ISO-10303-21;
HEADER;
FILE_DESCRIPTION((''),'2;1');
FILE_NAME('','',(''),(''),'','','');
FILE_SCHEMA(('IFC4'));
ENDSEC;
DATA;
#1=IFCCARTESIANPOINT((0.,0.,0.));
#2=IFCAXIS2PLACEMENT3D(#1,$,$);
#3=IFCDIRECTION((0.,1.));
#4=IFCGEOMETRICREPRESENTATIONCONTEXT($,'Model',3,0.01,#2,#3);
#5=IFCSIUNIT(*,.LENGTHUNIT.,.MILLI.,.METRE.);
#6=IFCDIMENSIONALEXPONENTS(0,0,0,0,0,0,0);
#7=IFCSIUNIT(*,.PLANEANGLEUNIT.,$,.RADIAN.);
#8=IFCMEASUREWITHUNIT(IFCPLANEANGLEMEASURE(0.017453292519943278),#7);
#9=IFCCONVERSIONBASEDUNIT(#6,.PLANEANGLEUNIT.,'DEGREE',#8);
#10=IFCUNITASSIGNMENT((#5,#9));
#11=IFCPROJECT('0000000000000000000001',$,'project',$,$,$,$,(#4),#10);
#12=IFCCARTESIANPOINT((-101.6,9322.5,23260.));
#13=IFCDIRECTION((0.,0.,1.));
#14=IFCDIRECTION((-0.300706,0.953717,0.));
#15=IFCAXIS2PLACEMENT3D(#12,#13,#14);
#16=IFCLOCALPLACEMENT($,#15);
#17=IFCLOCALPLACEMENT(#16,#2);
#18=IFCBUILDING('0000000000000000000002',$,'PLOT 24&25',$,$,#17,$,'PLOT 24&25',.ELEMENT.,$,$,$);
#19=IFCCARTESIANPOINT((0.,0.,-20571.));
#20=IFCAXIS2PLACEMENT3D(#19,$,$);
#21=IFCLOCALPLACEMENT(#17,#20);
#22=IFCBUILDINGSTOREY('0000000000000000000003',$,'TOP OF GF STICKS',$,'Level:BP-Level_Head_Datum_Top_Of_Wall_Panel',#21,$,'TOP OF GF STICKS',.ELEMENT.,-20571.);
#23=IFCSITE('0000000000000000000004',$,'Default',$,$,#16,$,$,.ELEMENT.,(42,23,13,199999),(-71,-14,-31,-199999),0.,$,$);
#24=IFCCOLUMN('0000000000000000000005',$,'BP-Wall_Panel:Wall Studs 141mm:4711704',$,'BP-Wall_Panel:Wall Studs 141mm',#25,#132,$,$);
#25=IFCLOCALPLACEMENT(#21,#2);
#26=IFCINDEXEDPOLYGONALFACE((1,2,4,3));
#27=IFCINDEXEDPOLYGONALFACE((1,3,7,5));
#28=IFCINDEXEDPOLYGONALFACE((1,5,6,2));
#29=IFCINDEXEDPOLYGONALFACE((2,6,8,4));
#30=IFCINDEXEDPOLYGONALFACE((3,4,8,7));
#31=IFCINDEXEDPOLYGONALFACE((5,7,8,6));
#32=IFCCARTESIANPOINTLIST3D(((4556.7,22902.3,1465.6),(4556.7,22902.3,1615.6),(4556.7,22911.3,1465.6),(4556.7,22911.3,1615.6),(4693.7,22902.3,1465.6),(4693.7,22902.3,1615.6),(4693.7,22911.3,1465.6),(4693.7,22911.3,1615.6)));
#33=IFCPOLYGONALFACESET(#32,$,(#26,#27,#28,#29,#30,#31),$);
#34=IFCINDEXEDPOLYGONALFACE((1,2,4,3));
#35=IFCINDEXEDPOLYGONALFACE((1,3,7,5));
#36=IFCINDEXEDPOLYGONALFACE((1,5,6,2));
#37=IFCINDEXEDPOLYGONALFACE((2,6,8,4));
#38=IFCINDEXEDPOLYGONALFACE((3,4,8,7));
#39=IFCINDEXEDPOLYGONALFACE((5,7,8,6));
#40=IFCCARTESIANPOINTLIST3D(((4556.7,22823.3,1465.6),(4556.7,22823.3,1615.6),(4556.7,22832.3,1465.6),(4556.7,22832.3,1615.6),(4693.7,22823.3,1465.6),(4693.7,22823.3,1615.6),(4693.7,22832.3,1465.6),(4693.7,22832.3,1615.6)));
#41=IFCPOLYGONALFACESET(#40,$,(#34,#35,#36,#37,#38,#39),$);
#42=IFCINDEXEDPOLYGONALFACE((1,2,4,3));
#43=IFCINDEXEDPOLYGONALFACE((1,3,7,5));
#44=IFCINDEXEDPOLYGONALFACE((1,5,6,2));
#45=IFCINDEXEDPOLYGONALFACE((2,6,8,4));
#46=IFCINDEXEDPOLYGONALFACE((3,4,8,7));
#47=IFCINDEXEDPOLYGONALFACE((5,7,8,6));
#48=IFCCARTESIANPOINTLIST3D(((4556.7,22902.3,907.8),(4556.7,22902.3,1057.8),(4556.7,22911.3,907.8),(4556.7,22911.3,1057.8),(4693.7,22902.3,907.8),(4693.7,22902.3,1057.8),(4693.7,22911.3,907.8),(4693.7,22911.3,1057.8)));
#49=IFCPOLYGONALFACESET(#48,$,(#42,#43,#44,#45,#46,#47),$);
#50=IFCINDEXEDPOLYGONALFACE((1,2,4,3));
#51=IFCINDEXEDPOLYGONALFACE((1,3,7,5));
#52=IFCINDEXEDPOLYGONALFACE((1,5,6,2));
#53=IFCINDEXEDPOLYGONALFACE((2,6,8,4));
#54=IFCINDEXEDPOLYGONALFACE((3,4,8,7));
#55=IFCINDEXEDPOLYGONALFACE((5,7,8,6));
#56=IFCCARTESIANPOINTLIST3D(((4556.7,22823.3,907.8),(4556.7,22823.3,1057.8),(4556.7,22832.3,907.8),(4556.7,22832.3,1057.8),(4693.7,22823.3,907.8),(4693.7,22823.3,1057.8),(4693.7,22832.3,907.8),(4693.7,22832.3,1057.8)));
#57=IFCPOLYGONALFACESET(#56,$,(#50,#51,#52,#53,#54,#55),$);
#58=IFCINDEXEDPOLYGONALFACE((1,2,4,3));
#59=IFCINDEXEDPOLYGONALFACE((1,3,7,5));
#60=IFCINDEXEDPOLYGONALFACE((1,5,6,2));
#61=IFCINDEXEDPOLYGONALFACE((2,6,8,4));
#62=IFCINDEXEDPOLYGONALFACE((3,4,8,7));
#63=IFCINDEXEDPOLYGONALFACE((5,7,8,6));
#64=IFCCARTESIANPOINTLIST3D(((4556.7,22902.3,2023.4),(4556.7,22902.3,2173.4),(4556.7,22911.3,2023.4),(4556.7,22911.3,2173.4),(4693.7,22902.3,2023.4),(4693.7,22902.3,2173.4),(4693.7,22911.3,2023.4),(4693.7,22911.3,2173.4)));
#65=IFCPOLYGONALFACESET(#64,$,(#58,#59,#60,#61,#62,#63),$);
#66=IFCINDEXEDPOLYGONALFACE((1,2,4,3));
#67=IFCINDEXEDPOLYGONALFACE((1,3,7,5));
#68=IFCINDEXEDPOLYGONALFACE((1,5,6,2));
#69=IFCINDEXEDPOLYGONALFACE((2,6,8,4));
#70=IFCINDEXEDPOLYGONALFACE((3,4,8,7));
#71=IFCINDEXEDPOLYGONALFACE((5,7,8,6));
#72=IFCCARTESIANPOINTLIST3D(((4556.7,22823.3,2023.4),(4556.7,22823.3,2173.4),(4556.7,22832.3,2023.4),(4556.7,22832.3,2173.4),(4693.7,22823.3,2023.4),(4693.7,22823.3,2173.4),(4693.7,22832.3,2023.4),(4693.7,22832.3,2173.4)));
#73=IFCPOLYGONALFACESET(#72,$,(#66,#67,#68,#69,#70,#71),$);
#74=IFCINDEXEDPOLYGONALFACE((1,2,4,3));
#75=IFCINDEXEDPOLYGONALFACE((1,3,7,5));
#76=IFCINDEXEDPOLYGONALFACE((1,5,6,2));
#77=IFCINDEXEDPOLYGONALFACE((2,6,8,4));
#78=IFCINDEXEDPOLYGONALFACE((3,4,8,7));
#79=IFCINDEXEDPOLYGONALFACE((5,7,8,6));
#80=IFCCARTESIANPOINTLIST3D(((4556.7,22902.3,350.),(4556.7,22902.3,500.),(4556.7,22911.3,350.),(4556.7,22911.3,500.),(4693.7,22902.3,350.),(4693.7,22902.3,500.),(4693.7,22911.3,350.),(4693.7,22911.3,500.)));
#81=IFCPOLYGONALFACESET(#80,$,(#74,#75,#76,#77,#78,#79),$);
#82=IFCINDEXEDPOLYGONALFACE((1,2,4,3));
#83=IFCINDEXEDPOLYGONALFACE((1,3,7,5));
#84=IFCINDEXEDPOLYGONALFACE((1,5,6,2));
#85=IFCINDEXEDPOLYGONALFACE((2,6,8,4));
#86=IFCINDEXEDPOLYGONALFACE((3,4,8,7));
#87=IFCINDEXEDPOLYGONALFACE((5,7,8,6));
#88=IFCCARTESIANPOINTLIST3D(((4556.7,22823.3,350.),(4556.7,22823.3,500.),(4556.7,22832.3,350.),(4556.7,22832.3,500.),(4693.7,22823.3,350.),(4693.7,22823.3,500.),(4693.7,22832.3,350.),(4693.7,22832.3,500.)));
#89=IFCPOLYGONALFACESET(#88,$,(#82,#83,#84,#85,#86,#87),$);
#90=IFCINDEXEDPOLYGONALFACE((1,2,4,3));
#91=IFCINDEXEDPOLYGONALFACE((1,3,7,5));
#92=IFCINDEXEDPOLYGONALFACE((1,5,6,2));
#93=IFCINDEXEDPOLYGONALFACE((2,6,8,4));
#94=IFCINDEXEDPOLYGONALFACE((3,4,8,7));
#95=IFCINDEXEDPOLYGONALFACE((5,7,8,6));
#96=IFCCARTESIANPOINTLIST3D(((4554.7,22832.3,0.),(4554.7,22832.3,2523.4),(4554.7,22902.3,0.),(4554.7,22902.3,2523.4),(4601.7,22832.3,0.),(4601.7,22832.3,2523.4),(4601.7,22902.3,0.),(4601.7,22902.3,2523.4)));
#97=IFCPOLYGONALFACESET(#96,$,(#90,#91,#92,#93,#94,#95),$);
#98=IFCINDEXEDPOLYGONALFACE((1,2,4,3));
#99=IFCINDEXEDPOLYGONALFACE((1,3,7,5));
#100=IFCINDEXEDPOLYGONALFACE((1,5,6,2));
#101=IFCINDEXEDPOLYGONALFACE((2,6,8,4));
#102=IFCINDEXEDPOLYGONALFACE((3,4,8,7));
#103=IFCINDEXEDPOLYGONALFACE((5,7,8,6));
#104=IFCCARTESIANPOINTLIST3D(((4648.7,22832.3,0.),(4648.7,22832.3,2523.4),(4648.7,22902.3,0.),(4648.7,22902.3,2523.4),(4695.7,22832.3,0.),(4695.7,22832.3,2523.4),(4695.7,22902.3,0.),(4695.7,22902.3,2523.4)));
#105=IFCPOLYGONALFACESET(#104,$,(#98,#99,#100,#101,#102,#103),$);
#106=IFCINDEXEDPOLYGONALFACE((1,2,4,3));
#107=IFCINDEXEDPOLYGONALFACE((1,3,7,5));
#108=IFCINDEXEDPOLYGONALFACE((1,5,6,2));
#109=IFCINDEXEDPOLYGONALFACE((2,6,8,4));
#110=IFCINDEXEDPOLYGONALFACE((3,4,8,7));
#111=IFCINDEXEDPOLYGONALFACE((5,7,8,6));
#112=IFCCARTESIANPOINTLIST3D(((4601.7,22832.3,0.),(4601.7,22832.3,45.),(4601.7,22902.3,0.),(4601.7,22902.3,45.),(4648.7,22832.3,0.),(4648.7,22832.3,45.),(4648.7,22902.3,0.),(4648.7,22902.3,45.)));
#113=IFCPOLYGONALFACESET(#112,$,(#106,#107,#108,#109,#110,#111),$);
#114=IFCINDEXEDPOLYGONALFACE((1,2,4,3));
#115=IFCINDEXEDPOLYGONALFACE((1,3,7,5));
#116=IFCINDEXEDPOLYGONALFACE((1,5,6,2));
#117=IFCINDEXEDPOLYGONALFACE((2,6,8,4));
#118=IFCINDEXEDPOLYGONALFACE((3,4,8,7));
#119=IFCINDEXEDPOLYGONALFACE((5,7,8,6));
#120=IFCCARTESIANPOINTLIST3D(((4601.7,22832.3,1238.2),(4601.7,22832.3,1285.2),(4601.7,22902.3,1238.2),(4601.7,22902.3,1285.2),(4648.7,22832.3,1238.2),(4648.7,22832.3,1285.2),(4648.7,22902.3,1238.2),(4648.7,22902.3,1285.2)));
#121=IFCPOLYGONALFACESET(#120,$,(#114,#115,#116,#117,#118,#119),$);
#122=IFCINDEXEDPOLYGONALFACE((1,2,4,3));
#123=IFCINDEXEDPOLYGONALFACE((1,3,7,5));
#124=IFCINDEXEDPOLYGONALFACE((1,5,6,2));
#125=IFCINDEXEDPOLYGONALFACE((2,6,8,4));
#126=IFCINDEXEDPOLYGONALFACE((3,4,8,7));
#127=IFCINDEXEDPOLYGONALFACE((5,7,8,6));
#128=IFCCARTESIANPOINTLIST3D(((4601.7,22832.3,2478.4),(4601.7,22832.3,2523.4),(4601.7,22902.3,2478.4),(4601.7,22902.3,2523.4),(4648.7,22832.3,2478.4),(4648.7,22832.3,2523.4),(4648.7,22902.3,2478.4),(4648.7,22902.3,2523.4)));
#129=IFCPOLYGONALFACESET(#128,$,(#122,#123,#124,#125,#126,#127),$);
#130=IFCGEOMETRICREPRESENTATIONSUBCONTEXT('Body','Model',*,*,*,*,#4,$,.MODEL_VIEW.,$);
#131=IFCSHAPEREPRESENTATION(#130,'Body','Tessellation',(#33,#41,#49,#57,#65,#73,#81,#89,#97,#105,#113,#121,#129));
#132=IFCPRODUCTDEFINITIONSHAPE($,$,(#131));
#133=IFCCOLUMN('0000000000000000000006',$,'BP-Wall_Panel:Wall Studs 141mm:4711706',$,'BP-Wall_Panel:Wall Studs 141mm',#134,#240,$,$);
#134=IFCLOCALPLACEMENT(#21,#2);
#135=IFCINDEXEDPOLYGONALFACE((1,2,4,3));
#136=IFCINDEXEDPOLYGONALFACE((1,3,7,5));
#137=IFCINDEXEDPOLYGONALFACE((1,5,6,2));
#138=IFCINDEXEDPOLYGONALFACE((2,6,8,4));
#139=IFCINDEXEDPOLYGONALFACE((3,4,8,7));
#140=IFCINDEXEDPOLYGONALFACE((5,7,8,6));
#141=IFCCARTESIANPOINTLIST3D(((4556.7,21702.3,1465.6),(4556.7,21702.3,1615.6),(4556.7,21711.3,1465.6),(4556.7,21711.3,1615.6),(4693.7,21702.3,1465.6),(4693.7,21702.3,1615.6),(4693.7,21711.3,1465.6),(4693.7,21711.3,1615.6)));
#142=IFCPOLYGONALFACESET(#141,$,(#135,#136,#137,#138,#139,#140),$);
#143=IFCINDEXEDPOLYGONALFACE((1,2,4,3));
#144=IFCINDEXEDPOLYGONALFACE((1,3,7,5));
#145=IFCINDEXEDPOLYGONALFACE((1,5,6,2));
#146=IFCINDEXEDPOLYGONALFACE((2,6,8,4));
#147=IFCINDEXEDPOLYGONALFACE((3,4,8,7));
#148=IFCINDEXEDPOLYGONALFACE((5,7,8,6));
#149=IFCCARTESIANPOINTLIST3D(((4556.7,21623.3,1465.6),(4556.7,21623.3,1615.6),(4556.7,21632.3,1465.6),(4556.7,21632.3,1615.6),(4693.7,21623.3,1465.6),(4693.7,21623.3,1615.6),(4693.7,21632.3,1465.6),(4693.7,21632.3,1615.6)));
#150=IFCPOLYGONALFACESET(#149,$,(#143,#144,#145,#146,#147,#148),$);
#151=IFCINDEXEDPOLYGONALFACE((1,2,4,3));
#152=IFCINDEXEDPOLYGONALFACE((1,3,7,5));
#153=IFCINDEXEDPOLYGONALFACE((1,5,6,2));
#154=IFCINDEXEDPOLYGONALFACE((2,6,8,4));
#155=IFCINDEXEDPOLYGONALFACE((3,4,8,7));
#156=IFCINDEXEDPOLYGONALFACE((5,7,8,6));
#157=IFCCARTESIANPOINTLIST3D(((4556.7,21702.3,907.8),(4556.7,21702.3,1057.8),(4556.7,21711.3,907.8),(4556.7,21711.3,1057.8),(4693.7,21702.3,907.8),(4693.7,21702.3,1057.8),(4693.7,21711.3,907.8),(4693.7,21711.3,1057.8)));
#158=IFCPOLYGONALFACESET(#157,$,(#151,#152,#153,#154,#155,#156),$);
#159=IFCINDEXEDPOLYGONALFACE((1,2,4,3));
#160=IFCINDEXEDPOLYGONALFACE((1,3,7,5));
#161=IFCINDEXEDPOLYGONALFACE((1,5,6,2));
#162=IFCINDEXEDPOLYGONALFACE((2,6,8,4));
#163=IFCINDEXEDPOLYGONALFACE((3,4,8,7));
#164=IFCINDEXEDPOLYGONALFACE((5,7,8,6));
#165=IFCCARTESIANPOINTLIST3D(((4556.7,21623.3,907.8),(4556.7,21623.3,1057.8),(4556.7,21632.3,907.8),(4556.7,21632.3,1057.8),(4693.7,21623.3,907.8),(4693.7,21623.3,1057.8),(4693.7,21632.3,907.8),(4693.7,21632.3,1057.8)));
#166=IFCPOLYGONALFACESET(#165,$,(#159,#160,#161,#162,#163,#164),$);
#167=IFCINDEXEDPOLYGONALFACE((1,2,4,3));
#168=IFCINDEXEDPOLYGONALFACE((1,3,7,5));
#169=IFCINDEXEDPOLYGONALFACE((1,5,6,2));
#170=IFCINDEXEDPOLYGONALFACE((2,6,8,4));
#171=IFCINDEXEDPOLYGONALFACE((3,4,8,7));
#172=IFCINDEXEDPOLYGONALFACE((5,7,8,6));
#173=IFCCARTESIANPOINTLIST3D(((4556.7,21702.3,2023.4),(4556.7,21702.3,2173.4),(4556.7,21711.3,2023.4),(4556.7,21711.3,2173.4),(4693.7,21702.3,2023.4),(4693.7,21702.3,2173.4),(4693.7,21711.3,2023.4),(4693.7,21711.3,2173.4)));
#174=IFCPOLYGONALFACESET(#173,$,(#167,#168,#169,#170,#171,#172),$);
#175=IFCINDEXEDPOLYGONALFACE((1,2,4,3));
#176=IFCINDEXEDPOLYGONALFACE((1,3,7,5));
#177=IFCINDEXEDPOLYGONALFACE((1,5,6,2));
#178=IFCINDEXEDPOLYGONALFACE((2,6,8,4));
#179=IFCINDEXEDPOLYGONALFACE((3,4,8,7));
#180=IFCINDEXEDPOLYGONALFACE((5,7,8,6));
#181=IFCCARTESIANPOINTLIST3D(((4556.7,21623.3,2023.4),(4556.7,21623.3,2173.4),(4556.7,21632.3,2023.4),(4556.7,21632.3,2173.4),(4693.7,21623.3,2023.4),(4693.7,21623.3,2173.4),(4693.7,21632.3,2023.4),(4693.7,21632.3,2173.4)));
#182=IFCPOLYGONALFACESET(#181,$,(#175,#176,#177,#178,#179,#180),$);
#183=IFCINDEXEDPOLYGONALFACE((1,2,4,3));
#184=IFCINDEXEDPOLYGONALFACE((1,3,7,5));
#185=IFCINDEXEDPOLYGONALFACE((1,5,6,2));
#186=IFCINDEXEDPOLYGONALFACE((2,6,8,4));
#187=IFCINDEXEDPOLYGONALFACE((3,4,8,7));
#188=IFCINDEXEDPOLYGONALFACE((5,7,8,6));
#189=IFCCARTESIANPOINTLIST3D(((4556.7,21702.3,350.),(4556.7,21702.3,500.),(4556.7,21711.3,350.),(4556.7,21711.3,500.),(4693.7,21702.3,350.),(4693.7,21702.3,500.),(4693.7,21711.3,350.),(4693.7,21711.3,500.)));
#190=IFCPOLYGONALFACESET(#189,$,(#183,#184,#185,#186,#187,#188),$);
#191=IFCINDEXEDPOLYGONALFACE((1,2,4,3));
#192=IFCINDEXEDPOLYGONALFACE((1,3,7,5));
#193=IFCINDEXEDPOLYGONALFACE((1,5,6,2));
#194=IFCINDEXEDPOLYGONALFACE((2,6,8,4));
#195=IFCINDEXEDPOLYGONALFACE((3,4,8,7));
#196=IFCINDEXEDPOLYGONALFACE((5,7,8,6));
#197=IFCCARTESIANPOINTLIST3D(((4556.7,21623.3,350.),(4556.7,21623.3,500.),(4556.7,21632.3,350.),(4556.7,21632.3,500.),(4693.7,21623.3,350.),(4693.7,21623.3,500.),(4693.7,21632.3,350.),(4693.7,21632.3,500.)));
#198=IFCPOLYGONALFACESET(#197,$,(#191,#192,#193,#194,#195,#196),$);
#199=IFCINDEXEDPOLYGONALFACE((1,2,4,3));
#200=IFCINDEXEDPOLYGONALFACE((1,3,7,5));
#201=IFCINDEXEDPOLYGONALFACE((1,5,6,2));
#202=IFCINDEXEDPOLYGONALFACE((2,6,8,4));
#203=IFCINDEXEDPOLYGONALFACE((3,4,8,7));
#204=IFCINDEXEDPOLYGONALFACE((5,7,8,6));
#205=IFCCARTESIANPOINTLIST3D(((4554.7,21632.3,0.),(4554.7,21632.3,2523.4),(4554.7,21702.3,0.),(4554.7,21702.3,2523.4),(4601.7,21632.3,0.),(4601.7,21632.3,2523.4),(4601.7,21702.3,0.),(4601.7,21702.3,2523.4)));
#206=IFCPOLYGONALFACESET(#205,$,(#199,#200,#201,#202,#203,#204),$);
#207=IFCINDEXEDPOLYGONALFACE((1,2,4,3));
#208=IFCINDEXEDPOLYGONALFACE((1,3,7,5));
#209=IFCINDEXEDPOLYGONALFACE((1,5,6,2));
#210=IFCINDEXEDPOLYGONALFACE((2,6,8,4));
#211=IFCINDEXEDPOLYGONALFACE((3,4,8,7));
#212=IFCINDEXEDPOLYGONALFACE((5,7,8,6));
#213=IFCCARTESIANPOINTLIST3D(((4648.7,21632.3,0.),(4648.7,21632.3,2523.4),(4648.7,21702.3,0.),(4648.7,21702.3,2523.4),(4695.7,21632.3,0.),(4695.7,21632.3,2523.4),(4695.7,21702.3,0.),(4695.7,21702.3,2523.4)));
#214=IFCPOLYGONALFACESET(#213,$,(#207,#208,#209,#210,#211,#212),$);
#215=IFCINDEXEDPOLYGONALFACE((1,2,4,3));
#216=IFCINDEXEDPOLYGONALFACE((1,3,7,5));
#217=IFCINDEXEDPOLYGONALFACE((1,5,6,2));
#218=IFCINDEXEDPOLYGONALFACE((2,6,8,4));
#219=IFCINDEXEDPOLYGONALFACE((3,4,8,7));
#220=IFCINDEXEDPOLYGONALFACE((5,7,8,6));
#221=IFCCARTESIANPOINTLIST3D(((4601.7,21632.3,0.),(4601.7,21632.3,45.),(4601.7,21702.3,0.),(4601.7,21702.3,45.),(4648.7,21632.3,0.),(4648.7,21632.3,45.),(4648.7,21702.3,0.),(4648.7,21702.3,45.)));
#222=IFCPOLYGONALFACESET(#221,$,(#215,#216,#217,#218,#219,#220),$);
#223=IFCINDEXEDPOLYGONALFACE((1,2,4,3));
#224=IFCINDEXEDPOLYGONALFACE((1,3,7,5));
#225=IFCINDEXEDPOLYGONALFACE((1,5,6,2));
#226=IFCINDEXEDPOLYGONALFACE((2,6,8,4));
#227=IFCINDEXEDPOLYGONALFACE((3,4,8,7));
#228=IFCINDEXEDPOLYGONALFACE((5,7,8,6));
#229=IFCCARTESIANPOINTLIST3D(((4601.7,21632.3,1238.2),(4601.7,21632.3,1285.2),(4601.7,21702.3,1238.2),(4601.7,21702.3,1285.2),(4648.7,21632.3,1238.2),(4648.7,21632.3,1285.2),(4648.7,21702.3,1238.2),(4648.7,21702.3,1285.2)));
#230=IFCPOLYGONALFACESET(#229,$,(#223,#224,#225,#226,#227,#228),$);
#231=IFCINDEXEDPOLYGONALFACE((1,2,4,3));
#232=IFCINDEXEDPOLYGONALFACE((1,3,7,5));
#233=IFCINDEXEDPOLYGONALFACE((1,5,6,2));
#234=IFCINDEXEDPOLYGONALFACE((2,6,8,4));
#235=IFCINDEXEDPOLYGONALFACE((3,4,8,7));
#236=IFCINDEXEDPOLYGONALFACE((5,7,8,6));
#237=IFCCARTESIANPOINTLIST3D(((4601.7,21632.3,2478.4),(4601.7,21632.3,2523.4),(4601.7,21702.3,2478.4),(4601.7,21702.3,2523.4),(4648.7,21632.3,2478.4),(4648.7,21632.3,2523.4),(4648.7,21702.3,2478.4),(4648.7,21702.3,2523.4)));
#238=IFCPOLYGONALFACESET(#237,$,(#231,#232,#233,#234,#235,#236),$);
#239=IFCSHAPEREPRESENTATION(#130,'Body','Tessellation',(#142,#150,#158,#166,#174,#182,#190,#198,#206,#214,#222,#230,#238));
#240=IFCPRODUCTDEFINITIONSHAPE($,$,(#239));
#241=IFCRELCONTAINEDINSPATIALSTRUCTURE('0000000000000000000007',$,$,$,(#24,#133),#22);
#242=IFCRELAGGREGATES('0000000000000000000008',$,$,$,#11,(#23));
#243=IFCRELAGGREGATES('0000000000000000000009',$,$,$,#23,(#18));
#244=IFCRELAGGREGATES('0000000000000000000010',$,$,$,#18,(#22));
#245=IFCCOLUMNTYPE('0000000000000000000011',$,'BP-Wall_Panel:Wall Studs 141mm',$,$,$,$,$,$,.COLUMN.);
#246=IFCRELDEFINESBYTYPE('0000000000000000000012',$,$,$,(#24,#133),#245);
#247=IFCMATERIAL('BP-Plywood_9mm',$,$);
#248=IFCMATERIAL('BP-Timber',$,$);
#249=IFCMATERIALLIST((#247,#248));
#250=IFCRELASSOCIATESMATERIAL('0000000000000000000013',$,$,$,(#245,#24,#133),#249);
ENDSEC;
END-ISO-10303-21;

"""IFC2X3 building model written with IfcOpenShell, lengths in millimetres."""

from ifc_helpers import new_model, entity, si_unit, converted_unit, direction, frame, frame_2d, origin, origin_2d_with_axis, place, context, subcontext, project, spatial, rectangle, extrude, source, transform, mapped, material, material_list, type_object, type_shapes, element, save


model = new_model("IFC2X3")

# Units and contexts
model_context = context("Model", 3, precision=0.01, world=origin(), true_north=direction((0.0, 1.0)))
body_context = subcontext(model_context, "Body", "Model", "MODEL_VIEW")
ifc_project = project(units=[si_unit("LENGTHUNIT", "METRE", prefix="MILLI"), converted_unit("PLANEANGLEUNIT", "DEGREE", entity("IfcPlaneAngleMeasure", 0.017453292519943278), si_unit("PLANEANGLEUNIT", "RADIAN"), dimensions=[0, 0, 0, 0, 0, 0, 0])], contexts=[model_context])

# Site, building, storey
site_placement = place(None, frame((-101.6, 9322.5, 23260.0), z_axis=(0.0, 0.0, 1.0), x_axis=(-0.300706, 0.953717, 0.0)))
site = spatial("IfcSite", under=ifc_project, at=site_placement, Name="Default", CompositionType="ELEMENT", RefLatitude=(42, 23, 13, 199999), RefLongitude=(-71, -14, -31, -199999), RefElevation=0.0)
building_placement = place(site_placement, origin())
building = spatial("IfcBuilding", under=site, at=building_placement, Name="PLOT 24&25", LongName="PLOT 24&25", CompositionType="ELEMENT")
storey_placement = place(building_placement, frame((0.0, 0.0, -20571.0)))
storey = spatial("IfcBuildingStorey", under=building, at=storey_placement, Name="TOP OF GF STICKS", ObjectType="Level:BP-Level_Head_Datum_Top_Of_Wall_Panel", LongName="TOP OF GF STICKS", CompositionType="ELEMENT", Elevation=-20571.0)

# Columns
ifc_material_1 = material(Name="BP-Plywood_9mm")
ifc_material_2 = material(Name="BP-Timber")
ifc_material_list = material_list([ifc_material_1, ifc_material_2])
column_type_1 = type_object("IfcColumnType", Name="BP-Wall_Panel:Wall Studs 141mm", PredefinedType="COLUMN", material=ifc_material_list)
shared_shape_1 = source(origin(), body_context, "Body", "SweptSolid", [
    extrude(rectangle(XDim=9.0, YDim=137.0, at=origin_2d_with_axis()), frame((39.5, 0.0, -19105.4)), (0.0, 0.0, 1.0), 150.0),
    extrude(rectangle(XDim=137.0, YDim=9.0, at=origin_2d_with_axis()), frame((-39.5, 0.0, -19105.4), z_axis=(0.0, 0.0, 1.0), x_axis=(0.0, 1.0, 0.0)), (0.0, 0.0, 1.0), 150.0),
    extrude(rectangle(XDim=9.0, YDim=137.0, at=origin_2d_with_axis()), frame((39.5, 0.0, -19663.2)), (0.0, 0.0, 1.0), 150.0),
    extrude(rectangle(XDim=137.0, YDim=9.0, at=origin_2d_with_axis()), frame((-39.5, 0.0, -19663.2), z_axis=(0.0, 0.0, 1.0), x_axis=(0.0, 1.0, 0.0)), (0.0, 0.0, 1.0), 150.0),
    extrude(rectangle(XDim=9.0, YDim=137.0, at=frame_2d((0.0, 0.0), x_axis=(1.0, 0.0))), frame((39.5, 0.0, -18547.6)), (0.0, 0.0, 1.0), 150.0),
    extrude(rectangle(XDim=137.0, YDim=9.0, at=origin_2d_with_axis()), frame((-39.5, 0.0, -18547.6), z_axis=(0.0, 0.0, 1.0), x_axis=(0.0, 1.0, 0.0)), (0.0, 0.0, 1.0), 150.0),
    extrude(rectangle(XDim=9.0, YDim=137.0, at=origin_2d_with_axis()), frame((39.5, 0.0, -20221.0)), (0.0, 0.0, 1.0), 150.0),
    extrude(rectangle(XDim=137.0, YDim=9.0, at=origin_2d_with_axis()), frame((-39.5, 0.0, -20221.0), z_axis=(0.0, 0.0, 1.0), x_axis=(0.0, 1.0, 0.0)), (0.0, 0.0, 1.0), 150.0),
    extrude(rectangle(XDim=47.0, YDim=70.0, at=origin_2d_with_axis()), frame((0.0, 47.0, -20571.0), z_axis=(0.0, 0.0, 1.0), x_axis=(0.0, 1.0, 0.0)), (0.0, 0.0, 1.0), 2523.4),
    extrude(rectangle(XDim=47.0, YDim=70.0, at=origin_2d_with_axis()), frame((0.0, -47.0, -20571.0), z_axis=(0.0, 0.0, 1.0), x_axis=(0.0, 1.0, 0.0)), (0.0, 0.0, 1.0), 2523.4),
    extrude(rectangle(XDim=70.0, YDim=47.0, at=origin_2d_with_axis()), frame((0.0, 0.0, -20571.0)), (0.0, 0.0, 1.0), 45.0),
    extrude(rectangle(XDim=70.0, YDim=47.0, at=origin_2d_with_axis()), frame((0.0, 0.0, -19332.8)), (0.0, 0.0, 1.0), 47.0),
    extrude(rectangle(XDim=70.0, YDim=47.0, at=origin_2d_with_axis()), frame((0.0, 0.0, -18092.6)), (0.0, 0.0, 1.0), 45.0),
])
type_shapes(column_type_1, [shared_shape_1])
for number, where, z_axis, x_axis, name in (
    (1, (4625.2, 22867.3, 20571.0), (0.0, 0.0, 1.0), (0.0, 1.0, 0.0), "BP-Wall_Panel:Wall Studs 141mm:4711704"),
    (2, (4625.2, 21667.3, 20571.0), (0.0, 0.0, 1.0), (0.0, 1.0, 0.0), "BP-Wall_Panel:Wall Studs 141mm:4711706"),
):
    element("IfcColumn", number, at=place(storey_placement, frame(where, z_axis=z_axis, x_axis=x_axis)), inside=storey, type_object=column_type_1, material=ifc_material_list, Name=name, ObjectType="BP-Wall_Panel:Wall Studs 141mm", context=body_context, shape_type="MappedRepresentation", body=[
        mapped(shared_shape_1, transform((0.0, 0.0, 0.0), scale=1.0)),
    ])

save(model, "model.ifc")
